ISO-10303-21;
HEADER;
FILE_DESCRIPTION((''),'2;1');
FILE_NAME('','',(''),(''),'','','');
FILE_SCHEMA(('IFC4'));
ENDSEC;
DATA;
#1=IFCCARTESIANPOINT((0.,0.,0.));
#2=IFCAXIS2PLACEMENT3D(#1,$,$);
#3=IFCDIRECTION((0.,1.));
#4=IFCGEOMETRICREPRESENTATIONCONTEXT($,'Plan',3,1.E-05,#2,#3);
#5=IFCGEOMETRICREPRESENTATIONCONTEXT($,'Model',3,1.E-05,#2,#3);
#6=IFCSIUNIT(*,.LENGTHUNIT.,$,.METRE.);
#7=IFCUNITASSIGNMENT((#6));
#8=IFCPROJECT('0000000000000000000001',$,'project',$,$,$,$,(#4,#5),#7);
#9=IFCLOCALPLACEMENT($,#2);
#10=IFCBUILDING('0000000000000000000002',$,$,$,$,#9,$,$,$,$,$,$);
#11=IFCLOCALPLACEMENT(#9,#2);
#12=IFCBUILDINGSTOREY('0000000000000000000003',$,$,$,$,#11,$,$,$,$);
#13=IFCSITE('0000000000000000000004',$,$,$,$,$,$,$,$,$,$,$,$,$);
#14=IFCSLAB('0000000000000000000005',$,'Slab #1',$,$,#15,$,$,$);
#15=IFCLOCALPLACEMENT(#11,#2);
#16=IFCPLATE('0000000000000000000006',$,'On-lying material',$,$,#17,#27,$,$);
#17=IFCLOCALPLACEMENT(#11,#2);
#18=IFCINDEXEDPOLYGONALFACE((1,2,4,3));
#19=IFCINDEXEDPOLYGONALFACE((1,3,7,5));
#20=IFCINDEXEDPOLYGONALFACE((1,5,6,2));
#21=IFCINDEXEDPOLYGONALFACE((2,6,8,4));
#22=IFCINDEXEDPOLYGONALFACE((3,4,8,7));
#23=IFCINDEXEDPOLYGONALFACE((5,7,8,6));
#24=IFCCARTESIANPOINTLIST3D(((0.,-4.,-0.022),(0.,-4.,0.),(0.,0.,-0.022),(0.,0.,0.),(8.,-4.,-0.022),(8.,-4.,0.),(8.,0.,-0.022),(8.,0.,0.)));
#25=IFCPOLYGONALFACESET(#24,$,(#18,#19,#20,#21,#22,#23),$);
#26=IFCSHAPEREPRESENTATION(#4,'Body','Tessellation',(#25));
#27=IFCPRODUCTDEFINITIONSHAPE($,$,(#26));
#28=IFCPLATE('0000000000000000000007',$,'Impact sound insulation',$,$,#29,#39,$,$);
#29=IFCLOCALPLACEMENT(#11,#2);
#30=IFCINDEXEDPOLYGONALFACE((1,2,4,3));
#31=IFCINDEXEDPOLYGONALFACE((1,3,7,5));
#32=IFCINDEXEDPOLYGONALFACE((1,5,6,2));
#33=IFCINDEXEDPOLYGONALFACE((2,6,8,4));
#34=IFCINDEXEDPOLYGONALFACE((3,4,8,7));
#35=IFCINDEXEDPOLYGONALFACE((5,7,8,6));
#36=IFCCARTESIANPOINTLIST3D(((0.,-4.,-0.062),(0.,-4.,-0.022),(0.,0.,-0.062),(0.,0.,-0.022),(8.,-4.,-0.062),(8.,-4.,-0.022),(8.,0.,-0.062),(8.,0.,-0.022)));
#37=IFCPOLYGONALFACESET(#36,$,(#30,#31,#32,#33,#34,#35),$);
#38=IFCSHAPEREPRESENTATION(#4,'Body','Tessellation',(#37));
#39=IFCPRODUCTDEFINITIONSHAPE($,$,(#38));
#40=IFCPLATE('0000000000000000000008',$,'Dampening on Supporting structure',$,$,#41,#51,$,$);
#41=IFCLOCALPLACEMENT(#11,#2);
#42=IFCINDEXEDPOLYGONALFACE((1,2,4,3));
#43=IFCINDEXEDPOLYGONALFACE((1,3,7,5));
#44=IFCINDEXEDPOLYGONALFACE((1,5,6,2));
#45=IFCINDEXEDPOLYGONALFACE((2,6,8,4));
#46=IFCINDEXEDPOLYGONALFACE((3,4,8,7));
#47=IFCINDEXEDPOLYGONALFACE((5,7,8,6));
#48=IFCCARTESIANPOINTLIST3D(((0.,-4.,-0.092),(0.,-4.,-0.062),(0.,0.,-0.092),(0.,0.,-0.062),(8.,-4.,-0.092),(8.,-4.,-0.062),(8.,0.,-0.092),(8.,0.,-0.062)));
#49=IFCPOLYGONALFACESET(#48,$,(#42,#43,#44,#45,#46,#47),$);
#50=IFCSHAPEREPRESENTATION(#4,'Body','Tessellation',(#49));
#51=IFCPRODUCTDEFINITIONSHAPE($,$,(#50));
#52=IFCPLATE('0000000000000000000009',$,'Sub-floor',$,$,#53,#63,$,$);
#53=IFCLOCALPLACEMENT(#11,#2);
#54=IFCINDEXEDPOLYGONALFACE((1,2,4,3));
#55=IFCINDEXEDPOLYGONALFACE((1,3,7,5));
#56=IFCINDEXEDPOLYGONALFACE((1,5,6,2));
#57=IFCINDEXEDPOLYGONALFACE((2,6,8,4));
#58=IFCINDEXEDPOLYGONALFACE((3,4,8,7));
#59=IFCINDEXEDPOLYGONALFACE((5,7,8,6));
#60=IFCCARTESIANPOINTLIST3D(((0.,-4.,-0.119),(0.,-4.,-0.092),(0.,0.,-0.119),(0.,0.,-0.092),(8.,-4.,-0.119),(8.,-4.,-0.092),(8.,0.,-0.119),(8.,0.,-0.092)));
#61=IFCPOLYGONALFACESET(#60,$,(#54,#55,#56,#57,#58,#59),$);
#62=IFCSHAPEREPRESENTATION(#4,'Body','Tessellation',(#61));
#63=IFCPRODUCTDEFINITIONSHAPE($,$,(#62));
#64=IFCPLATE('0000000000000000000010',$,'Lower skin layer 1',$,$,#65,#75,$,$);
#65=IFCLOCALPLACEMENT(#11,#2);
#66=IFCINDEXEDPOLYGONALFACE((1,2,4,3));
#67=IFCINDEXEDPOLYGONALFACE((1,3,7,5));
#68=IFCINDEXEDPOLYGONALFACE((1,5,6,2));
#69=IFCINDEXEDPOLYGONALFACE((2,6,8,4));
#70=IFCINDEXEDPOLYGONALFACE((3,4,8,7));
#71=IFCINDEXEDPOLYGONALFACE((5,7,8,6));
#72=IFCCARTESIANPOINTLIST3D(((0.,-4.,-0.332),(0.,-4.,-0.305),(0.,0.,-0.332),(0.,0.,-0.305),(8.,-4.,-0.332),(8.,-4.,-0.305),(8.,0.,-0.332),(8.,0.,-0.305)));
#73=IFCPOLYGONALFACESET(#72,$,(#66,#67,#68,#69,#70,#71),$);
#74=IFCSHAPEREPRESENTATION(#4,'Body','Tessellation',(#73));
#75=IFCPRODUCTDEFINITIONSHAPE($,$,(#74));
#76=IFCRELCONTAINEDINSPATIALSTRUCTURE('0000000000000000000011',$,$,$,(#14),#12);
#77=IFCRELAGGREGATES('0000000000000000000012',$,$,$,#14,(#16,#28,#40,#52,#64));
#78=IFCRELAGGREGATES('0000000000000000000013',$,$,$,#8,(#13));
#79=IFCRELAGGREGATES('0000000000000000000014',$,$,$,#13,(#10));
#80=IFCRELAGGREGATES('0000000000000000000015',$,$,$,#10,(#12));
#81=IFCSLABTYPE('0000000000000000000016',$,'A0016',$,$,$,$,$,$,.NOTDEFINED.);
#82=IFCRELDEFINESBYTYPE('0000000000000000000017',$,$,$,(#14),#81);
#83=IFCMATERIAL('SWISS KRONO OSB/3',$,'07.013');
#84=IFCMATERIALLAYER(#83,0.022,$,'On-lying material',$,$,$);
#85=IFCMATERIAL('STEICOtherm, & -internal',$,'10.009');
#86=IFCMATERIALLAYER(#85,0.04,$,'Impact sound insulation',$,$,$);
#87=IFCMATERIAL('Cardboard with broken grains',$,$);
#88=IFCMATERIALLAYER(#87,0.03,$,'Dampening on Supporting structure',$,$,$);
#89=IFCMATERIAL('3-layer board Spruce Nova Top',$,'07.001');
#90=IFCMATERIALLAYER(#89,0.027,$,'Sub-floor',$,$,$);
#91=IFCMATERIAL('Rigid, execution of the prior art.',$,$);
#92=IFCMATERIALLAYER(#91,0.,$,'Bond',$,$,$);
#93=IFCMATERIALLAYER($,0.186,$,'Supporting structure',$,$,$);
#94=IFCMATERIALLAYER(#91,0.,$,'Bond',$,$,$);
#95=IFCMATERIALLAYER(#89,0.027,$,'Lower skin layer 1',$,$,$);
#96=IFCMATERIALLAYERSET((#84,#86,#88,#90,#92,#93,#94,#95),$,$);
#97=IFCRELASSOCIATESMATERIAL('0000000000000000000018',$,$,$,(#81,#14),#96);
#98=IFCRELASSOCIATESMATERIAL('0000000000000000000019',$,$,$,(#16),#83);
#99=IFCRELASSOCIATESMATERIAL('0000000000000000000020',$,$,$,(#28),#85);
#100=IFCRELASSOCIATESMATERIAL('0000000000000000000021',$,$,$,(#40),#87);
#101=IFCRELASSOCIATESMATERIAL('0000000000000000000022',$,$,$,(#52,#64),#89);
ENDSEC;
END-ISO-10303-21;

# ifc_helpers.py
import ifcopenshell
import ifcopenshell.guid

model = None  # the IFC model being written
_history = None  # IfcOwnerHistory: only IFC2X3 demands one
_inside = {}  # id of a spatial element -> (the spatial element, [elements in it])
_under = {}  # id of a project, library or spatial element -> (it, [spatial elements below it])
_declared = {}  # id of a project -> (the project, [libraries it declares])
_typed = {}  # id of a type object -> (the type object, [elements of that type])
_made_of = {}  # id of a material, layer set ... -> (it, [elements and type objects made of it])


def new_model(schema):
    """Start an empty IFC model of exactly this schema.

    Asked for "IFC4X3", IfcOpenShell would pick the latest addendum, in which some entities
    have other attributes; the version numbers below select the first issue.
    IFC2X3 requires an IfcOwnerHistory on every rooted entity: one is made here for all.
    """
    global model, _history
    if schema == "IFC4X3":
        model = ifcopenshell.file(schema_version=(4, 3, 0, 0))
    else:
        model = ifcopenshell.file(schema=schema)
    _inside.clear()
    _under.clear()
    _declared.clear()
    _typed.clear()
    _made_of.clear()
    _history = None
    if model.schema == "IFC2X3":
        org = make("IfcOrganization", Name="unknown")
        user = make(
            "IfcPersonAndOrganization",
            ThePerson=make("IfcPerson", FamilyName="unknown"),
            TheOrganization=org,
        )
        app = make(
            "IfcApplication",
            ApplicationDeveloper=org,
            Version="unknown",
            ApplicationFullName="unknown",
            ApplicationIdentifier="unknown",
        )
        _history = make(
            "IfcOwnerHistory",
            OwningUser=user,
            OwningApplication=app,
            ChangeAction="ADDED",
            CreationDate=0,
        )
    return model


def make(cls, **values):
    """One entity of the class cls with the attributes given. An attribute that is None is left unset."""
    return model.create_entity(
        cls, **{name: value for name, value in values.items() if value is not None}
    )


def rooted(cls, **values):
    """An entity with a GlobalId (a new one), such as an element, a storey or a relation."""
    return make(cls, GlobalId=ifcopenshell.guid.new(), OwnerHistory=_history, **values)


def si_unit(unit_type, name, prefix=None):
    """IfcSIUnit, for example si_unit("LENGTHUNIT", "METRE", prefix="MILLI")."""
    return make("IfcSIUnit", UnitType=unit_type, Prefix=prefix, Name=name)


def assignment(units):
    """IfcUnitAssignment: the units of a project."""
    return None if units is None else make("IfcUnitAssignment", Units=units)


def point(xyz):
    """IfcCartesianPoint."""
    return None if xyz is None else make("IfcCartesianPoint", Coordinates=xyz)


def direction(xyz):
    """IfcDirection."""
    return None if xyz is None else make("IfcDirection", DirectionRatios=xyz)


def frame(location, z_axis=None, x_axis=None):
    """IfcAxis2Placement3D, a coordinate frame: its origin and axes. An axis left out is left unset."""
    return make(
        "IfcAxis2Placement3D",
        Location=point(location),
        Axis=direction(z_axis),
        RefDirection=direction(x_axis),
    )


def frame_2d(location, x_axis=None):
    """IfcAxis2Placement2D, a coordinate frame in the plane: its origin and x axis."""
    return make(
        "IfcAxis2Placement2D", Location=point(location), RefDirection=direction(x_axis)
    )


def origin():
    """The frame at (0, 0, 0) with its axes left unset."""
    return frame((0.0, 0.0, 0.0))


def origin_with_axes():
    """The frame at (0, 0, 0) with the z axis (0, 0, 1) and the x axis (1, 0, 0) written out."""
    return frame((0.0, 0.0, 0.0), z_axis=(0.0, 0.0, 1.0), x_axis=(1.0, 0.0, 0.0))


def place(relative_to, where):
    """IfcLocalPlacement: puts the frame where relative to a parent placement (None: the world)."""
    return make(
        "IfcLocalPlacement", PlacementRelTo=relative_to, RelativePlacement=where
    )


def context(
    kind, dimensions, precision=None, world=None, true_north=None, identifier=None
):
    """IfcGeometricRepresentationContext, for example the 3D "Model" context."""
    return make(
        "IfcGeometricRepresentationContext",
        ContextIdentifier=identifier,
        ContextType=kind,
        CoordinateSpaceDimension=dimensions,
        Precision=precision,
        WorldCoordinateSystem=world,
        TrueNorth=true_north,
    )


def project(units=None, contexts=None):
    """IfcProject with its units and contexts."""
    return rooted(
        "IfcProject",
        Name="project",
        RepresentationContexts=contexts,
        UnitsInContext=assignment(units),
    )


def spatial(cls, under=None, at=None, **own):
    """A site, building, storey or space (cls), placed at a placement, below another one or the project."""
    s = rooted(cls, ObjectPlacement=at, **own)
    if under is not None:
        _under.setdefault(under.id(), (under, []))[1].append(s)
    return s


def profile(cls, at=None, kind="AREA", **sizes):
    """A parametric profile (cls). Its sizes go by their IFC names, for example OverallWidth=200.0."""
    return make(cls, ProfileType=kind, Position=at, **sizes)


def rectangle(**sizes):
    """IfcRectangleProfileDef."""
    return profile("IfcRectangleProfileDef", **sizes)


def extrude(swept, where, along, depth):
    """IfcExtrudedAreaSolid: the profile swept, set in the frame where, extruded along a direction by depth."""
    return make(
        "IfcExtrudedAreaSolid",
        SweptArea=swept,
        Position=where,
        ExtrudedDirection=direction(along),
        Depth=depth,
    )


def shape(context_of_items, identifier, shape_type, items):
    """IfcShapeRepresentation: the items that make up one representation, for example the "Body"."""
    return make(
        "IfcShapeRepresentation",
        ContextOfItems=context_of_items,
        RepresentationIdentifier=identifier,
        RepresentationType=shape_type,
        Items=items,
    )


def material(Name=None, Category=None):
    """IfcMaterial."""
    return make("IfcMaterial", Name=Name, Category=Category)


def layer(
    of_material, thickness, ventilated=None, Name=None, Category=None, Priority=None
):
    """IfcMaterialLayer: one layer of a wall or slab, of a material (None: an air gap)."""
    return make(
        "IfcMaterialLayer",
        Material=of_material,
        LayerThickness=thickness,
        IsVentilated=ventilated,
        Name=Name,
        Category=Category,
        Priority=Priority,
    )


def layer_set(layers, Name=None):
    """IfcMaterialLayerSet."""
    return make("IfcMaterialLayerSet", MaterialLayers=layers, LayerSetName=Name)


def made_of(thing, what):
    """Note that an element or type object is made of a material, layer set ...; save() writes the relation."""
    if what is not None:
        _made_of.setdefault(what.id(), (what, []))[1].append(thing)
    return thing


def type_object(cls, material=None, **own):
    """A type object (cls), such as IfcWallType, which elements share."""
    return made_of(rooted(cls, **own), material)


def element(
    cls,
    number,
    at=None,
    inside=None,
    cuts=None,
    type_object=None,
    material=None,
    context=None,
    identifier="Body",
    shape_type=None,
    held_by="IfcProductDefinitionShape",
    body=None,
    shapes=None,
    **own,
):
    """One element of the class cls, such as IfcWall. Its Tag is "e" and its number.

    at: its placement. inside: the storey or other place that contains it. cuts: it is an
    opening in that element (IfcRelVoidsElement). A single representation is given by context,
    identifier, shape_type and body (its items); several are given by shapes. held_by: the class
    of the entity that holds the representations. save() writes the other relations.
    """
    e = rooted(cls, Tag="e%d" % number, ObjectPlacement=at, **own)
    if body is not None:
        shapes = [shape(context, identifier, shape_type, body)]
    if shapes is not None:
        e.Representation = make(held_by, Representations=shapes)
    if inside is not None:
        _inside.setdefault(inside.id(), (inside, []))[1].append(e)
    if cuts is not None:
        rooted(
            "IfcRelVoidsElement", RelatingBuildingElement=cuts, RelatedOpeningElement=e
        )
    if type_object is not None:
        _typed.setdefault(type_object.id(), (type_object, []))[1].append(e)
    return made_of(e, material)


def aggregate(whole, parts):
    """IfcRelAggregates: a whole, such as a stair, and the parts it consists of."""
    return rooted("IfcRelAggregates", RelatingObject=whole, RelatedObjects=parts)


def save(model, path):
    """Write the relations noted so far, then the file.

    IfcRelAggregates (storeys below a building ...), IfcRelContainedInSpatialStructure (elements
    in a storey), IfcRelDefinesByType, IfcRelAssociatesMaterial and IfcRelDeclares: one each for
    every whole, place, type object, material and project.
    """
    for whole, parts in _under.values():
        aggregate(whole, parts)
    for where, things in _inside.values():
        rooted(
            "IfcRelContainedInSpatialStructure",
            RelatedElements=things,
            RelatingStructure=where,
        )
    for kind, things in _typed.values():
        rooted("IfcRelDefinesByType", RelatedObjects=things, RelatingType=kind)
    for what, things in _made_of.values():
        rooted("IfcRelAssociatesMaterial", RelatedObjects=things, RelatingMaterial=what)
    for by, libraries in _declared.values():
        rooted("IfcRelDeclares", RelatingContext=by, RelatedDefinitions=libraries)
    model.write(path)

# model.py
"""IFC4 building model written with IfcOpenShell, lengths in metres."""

from ifc_helpers import new_model, si_unit, direction, frame, frame_2d, origin, origin_with_axes, place, context, project, spatial, rectangle, extrude, material, layer, layer_set, type_object, element, aggregate, save


model = new_model("IFC4")

# Units and contexts
plan_context = context("Plan", 3, precision=1e-05, world=origin(), true_north=direction((0.0, 1.0)))
model_context = context("Model", 3, precision=1e-05, world=origin(), true_north=direction((0.0, 1.0)))
ifc_project = project(units=[si_unit("LENGTHUNIT", "METRE")], contexts=[plan_context, model_context])

# Site, building, storey
site = spatial("IfcSite", under=ifc_project)
building_placement = place(None, origin())
building = spatial("IfcBuilding", under=site, at=building_placement)
storey_placement = place(building_placement, origin())
storey = spatial("IfcBuildingStorey", under=building, at=storey_placement)

# Slab, plates
ifc_material_1 = material(Name="SWISS KRONO OSB/3", Category="07.013")
ifc_layer_1 = layer(ifc_material_1, 0.022, Name="On-lying material")
ifc_material_2 = material(Name="STEICOtherm, & -internal", Category="10.009")
ifc_layer_2 = layer(ifc_material_2, 0.04, Name="Impact sound insulation")
ifc_material_3 = material(Name="Cardboard with broken grains")
ifc_layer_3 = layer(ifc_material_3, 0.03, Name="Dampening on Supporting structure")
ifc_material_4 = material(Name="3-layer board Spruce Nova Top", Category="07.001")
ifc_layer_4 = layer(ifc_material_4, 0.027, Name="Sub-floor")
ifc_material_5 = material(Name="Rigid, execution of the prior art.")
ifc_layer_5 = layer(ifc_material_5, 0.0, Name="Bond")
ifc_layer_6 = layer(None, 0.186, Name="Supporting structure")
ifc_layer_7 = layer(ifc_material_5, 0.0, Name="Bond")
ifc_layer_8 = layer(ifc_material_4, 0.027, Name="Lower skin layer 1")
ifc_layer_set = layer_set([ifc_layer_1, ifc_layer_2, ifc_layer_3, ifc_layer_4, ifc_layer_5, ifc_layer_6, ifc_layer_7, ifc_layer_8])
slab_type = type_object("IfcSlabType", Name="A0016", PredefinedType="NOTDEFINED", material=ifc_layer_set)
slab_placement = place(None, frame((0.0, 0.0, 0.0), z_axis=(0.0, 0.0, -1.0), x_axis=(1.0, 0.0, 0.0)))
slab = element("IfcSlab", 1, at=slab_placement, inside=storey, type_object=slab_type, material=ifc_layer_set, Name="Slab #1")
plate_1_placement = place(slab_placement, origin())
plate_1 = element("IfcPlate", 2, at=plate_1_placement, material=ifc_material_1, Name="On-lying material", context=plan_context, shape_type="SweptSolid", body=[
    extrude(rectangle(XDim=8.0, YDim=4.0, at=frame_2d((4.0, 2.0), x_axis=(1.0, 0.0))), origin_with_axes(), (0.0, 0.0, 1.0), 0.022),
])
plate_2_placement = place(slab_placement, origin())
plate_2 = element("IfcPlate", 3, at=plate_2_placement, material=ifc_material_2, Name="Impact sound insulation", context=plan_context, shape_type="SweptSolid", body=[
    extrude(rectangle(XDim=8.0, YDim=4.0, at=frame_2d((4.0, 2.0), x_axis=(1.0, 0.0))), frame((0.0, 0.0, 0.022), z_axis=(0.0, 0.0, 1.0), x_axis=(1.0, 0.0, 0.0)), (0.0, 0.0, 1.0), 0.04),
])
plate_3_placement = place(slab_placement, origin())
plate_3 = element("IfcPlate", 4, at=plate_3_placement, material=ifc_material_3, Name="Dampening on Supporting structure", context=plan_context, shape_type="SweptSolid", body=[
    extrude(rectangle(XDim=8.0, YDim=4.0, at=frame_2d((4.0, 2.0), x_axis=(1.0, 0.0))), frame((0.0, 0.0, 0.062), z_axis=(0.0, 0.0, 1.0), x_axis=(1.0, 0.0, 0.0)), (0.0, 0.0, 1.0), 0.03),
])
plate_4_placement = place(slab_placement, origin())
plate_4 = element("IfcPlate", 5, at=plate_4_placement, material=ifc_material_4, Name="Sub-floor", context=plan_context, shape_type="SweptSolid", body=[
    extrude(rectangle(XDim=8.0, YDim=4.0, at=frame_2d((4.0, 2.0), x_axis=(1.0, 0.0))), frame((0.0, 0.0, 0.092), z_axis=(0.0, 0.0, 1.0), x_axis=(1.0, 0.0, 0.0)), (0.0, 0.0, 1.0), 0.027),
])
plate_5_placement = place(slab_placement, origin())
plate_5 = element("IfcPlate", 6, at=plate_5_placement, material=ifc_material_4, Name="Lower skin layer 1", context=plan_context, shape_type="SweptSolid", body=[
    extrude(rectangle(XDim=8.0, YDim=4.0, at=frame_2d((4.0, 2.0), x_axis=(1.0, 0.0))), frame((0.0, 0.0, 0.305), z_axis=(0.0, 0.0, 1.0), x_axis=(1.0, 0.0, 0.0)), (0.0, 0.0, 1.0), 0.027),
])
aggregate(slab, [plate_1, plate_2, plate_3, plate_4, plate_5])

save(model, "model.ifc")
